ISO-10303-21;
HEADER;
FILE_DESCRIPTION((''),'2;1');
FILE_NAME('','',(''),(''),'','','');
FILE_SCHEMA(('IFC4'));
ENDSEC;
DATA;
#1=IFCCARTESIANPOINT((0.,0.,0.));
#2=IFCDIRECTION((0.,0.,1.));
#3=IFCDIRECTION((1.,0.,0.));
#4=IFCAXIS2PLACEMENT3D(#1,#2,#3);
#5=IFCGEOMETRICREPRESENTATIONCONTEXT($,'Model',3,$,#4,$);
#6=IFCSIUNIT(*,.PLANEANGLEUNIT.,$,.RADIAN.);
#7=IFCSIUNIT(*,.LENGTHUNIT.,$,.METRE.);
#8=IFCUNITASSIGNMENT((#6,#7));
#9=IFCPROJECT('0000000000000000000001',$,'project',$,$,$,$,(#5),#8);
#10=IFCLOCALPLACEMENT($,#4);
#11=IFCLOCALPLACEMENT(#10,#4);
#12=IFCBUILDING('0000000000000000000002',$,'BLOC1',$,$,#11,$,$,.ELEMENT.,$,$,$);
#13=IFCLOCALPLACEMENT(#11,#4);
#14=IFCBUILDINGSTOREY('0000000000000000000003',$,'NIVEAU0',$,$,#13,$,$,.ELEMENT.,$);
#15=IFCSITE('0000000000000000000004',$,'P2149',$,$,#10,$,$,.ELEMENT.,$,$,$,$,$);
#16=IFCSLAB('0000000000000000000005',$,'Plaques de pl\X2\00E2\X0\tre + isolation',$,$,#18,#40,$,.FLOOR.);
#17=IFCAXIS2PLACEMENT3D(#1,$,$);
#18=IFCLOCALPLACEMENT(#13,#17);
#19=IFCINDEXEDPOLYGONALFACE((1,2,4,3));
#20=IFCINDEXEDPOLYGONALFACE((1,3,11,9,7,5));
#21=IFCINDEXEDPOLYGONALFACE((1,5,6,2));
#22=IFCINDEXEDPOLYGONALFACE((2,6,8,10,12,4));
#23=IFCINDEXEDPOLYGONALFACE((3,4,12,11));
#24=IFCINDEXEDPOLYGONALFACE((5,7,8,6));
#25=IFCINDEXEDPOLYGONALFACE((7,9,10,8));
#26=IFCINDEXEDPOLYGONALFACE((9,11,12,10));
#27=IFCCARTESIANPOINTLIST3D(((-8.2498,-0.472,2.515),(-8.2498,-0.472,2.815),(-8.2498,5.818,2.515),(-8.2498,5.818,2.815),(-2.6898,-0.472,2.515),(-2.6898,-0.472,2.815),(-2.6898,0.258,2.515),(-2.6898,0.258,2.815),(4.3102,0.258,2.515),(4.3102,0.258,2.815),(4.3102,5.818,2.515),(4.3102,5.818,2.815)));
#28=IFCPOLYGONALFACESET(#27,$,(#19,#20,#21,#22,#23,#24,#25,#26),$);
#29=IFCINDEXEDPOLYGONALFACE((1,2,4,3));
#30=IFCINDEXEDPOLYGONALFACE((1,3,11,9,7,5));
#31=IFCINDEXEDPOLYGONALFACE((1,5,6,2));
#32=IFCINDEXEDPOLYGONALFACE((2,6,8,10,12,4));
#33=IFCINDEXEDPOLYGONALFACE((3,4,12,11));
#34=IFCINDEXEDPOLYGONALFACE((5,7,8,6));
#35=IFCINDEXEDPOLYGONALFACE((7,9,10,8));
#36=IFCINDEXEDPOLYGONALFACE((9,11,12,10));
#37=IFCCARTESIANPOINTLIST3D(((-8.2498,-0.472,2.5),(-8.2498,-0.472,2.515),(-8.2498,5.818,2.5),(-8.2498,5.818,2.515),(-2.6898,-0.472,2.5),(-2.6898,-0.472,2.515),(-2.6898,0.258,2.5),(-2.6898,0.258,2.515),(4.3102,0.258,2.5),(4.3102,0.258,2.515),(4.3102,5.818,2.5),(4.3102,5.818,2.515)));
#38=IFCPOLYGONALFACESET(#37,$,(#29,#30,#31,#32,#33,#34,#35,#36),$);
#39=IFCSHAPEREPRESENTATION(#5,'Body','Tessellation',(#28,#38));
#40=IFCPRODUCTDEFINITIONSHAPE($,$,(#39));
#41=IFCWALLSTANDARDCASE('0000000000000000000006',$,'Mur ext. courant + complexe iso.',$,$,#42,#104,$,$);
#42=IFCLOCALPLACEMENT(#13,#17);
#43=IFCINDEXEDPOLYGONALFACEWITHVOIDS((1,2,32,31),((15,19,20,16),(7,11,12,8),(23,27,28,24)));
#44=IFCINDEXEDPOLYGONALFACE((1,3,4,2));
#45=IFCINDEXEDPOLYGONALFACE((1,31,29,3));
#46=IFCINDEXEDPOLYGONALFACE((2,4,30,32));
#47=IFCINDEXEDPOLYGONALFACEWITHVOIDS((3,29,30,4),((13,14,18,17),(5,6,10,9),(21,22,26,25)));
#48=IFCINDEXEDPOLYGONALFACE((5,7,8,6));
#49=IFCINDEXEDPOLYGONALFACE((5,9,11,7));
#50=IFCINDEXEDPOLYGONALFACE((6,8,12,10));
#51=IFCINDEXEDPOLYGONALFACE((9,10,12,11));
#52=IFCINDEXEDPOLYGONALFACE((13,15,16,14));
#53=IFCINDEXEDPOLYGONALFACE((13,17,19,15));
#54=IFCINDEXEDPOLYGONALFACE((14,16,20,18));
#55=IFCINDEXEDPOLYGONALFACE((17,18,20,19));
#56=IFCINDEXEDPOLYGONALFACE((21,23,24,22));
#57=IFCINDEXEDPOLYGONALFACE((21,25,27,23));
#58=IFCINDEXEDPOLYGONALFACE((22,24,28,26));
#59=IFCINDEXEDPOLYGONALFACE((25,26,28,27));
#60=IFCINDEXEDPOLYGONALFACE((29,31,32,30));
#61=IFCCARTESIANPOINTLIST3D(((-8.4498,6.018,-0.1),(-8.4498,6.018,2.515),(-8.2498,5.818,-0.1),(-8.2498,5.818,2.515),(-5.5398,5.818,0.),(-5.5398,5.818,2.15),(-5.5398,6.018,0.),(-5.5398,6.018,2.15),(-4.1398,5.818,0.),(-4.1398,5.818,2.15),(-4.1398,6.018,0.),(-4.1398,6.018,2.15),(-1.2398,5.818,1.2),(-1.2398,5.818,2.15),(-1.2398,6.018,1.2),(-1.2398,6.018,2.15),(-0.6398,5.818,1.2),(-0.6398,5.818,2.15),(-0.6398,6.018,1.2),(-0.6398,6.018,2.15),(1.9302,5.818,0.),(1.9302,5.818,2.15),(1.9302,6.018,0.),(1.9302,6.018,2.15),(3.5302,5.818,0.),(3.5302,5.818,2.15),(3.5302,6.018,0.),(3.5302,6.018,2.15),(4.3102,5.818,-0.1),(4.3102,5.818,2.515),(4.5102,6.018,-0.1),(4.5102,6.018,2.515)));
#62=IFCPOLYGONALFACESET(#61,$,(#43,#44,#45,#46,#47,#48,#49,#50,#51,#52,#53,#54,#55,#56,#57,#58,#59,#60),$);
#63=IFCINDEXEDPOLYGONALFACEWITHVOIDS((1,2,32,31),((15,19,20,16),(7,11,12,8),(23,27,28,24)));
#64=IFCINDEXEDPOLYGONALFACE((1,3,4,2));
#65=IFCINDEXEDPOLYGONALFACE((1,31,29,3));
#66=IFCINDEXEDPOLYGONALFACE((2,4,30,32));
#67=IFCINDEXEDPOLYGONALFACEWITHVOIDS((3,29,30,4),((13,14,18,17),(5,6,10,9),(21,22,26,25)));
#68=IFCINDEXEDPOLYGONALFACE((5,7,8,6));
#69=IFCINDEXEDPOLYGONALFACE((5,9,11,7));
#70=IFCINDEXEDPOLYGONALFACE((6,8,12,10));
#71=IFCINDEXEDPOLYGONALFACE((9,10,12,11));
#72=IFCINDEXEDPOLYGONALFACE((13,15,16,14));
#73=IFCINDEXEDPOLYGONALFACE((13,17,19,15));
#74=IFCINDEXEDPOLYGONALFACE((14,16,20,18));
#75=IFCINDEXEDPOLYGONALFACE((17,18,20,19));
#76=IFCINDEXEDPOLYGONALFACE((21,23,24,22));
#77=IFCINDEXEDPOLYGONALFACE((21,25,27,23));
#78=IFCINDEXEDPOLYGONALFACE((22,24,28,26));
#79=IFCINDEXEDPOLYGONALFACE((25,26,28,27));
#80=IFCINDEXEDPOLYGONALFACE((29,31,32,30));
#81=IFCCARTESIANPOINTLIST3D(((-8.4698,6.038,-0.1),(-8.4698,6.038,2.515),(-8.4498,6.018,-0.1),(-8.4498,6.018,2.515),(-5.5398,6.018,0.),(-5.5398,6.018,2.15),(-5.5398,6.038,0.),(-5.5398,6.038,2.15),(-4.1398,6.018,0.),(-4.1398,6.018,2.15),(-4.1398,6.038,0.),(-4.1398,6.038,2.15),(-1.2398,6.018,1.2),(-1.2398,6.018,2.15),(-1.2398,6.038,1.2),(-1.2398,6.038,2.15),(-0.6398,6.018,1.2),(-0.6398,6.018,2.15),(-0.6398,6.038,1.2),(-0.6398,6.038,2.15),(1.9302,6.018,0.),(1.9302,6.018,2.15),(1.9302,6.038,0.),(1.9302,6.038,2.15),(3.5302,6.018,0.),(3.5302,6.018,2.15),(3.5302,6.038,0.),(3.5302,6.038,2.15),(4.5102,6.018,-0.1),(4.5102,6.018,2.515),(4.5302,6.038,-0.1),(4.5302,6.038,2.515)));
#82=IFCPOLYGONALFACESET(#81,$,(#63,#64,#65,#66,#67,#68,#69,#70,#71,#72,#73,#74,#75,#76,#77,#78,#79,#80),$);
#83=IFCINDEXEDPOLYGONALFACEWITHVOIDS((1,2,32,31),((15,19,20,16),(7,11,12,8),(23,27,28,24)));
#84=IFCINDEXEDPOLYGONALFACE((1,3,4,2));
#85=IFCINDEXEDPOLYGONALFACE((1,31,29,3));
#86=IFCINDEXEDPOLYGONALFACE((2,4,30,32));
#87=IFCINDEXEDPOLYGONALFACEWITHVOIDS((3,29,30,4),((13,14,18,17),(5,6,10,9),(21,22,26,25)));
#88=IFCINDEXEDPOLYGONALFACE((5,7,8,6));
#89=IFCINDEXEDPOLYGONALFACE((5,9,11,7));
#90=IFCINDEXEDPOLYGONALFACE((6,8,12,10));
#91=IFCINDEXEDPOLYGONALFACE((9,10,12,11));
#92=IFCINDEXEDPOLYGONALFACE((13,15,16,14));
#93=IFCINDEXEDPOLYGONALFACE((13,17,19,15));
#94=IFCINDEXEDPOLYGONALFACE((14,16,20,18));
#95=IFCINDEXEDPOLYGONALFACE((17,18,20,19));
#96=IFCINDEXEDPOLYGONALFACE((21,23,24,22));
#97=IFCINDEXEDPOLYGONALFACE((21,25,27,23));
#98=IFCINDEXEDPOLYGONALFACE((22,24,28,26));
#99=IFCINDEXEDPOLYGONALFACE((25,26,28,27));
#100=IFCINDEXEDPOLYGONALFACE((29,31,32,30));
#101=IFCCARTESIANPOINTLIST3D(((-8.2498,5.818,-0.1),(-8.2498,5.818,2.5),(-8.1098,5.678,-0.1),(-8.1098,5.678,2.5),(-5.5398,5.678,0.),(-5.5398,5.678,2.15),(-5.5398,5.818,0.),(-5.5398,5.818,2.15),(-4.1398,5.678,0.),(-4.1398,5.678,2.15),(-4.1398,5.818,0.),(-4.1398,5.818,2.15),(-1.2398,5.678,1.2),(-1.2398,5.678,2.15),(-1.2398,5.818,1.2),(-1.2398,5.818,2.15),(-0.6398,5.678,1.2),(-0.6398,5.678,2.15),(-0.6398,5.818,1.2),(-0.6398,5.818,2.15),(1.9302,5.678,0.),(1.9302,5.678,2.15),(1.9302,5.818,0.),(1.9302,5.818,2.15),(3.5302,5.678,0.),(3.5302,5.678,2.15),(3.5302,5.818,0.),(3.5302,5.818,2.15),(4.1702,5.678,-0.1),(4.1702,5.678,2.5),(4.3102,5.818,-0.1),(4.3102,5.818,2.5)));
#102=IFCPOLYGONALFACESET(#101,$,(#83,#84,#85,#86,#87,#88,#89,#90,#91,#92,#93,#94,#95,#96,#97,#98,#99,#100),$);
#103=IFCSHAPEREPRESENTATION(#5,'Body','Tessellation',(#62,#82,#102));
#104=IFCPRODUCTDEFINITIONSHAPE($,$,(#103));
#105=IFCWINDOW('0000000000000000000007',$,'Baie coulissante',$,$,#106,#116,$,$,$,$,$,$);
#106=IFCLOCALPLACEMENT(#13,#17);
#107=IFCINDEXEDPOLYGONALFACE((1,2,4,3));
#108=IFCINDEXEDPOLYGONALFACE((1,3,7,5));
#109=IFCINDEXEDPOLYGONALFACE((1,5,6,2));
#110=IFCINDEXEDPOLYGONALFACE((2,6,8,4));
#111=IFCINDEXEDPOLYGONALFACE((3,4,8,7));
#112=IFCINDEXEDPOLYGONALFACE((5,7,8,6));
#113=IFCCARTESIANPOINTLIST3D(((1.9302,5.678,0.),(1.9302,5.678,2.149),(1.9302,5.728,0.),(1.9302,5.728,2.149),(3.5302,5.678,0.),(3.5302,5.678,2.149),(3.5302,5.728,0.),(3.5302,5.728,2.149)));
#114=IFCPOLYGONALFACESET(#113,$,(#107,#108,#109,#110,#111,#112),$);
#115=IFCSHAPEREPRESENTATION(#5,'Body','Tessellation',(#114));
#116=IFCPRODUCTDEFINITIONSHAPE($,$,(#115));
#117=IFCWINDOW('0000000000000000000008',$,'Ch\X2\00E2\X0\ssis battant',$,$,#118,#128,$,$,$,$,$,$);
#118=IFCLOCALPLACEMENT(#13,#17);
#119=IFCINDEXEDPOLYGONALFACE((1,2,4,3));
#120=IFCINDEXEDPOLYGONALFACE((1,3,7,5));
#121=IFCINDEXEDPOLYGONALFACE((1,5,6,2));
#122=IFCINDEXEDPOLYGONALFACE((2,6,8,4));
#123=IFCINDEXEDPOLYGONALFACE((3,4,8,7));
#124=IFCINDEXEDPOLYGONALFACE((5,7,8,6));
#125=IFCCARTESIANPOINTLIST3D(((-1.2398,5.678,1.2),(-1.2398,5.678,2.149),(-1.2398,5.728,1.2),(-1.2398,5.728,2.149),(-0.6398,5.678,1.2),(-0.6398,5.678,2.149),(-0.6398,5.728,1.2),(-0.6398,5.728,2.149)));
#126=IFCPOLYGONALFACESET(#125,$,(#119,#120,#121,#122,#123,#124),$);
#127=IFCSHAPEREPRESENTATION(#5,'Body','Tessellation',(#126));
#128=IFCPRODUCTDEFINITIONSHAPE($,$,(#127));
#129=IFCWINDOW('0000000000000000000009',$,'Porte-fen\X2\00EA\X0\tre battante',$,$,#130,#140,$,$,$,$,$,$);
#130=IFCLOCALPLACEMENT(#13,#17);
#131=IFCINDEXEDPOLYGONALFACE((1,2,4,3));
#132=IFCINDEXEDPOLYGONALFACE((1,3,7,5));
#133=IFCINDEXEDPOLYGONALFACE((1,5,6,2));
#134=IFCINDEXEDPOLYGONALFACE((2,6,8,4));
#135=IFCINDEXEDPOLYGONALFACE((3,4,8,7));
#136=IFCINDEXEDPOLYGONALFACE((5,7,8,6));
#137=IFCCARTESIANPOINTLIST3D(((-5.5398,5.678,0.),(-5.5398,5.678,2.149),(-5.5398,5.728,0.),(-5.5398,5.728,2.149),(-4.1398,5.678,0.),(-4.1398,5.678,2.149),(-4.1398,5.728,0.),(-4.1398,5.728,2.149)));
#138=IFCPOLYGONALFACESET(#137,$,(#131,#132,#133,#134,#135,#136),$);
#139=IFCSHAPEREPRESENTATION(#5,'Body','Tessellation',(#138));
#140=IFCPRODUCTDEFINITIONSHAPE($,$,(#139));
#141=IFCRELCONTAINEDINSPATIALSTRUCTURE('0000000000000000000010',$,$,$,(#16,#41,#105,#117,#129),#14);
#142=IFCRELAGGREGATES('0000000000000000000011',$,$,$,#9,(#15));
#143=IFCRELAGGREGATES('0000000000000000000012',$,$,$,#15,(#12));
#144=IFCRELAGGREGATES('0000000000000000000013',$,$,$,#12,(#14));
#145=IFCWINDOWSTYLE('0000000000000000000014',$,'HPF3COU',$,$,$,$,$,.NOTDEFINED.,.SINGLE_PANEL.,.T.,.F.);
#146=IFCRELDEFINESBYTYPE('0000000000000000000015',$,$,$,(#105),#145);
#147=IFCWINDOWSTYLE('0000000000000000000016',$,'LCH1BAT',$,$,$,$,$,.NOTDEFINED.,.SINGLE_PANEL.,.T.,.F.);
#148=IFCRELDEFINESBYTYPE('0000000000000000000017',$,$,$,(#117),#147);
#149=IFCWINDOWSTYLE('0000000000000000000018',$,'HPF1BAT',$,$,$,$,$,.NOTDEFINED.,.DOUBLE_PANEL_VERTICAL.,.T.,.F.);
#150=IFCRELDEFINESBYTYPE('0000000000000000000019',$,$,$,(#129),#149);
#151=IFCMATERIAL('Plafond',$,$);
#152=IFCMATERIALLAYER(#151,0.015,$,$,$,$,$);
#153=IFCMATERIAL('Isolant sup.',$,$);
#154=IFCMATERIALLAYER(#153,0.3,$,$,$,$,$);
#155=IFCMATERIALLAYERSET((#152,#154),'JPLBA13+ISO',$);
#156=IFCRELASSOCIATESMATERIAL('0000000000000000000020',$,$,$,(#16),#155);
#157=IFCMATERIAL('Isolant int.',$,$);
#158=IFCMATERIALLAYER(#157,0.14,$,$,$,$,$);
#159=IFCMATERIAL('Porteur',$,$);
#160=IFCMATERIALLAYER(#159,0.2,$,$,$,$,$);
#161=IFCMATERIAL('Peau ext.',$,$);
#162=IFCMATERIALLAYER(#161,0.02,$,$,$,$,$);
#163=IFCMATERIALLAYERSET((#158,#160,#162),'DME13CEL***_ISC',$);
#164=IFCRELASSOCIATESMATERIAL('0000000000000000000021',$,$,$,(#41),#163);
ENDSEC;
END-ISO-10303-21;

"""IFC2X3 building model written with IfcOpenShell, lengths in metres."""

from ifc_helpers import new_model, si_unit, point, frame, frame_2d, origin_with_axes, place, context, project, spatial, line_curve, trimmed, segment, composite_curve, rectangle, outline, extrude, clip, bounded_halfspace, material, layer, layer_set, layer_usage, type_object, element, fill, save


model = new_model("IFC2X3")

# Units and contexts
model_context = context("Model", 3, world=origin_with_axes())
ifc_project = project(units=[si_unit("PLANEANGLEUNIT", "RADIAN"), si_unit("LENGTHUNIT", "METRE")], contexts=[model_context])

# Site, building, storey
site_placement = place(None, origin_with_axes())
site = spatial("IfcSite", under=ifc_project, at=site_placement, Name="P2149", CompositionType="ELEMENT")
building_placement = place(site_placement, origin_with_axes())
building = spatial("IfcBuilding", under=site, at=building_placement, Name="BLOC1", CompositionType="ELEMENT")
storey_placement = place(building_placement, origin_with_axes())
storey = spatial("IfcBuildingStorey", under=building, at=storey_placement, Name="NIVEAU0", CompositionType="ELEMENT")

# Slab
ifc_material_1 = material(Name="Plafond")
ifc_layer_1 = layer(ifc_material_1, 0.015)
ifc_material_2 = material(Name="Isolant sup.")
ifc_layer_2 = layer(ifc_material_2, 0.3)
ifc_layer_set_1 = layer_set([ifc_layer_1, ifc_layer_2], Name="JPLBA13+ISO")
ifc_layer_usage_1 = layer_usage(ifc_layer_set_1, "AXIS3", "POSITIVE", 0.0)
slab_placement = place(storey_placement, origin_with_axes())
element("IfcSlab", 1, at=slab_placement, inside=storey, material=ifc_layer_usage_1, Name="Plaques de plâtre + isolation", PredefinedType="FLOOR", context=model_context, shape_type="SweptSolid", body=[
    extrude(outline(composite_curve([segment(trimmed(line_curve((-8.2498, -0.472), (1.0, 0.0), 5.56), [point((-8.2498, -0.472))], [point((-2.6898, -0.472))], True, "CARTESIAN"), True, "CONTINUOUS"), segment(trimmed(line_curve((-2.6898, -0.472), (0.0, 1.0), 0.73), [point((-2.6898, -0.472))], [point((-2.6898, 0.258))], True, "CARTESIAN"), True, "CONTINUOUS"), segment(trimmed(line_curve((-2.6898, 0.258), (1.0, 0.0), 7.0), [point((-2.6898, 0.258))], [point((4.3102, 0.258))], True, "CARTESIAN"), True, "CONTINUOUS"), segment(trimmed(line_curve((4.3102, 0.258), (0.0, 1.0), 5.56), [point((4.3102, 0.258))], [point((4.3102, 5.818))], True, "CARTESIAN"), True, "CONTINUOUS"), segment(trimmed(line_curve((4.3102, 5.818), (-1.0, 0.0), 12.56), [point((4.3102, 5.818))], [point((-8.2498, 5.818))], True, "CARTESIAN"), True, "CONTINUOUS"), segment(trimmed(line_curve((-8.2498, 5.818), (0.0, -1.0), 6.29), [point((-8.2498, 5.818))], [point((-8.2498, -0.472))], True, "CARTESIAN"), True, "CONTINUOUS")], self_intersect=False)), frame((0.0, 0.0, 2.515), z_axis=(0.0, 0.0, 1.0), x_axis=(1.0, 0.0, 0.0)), (0.0, 0.0, 1.0), 0.3),
    extrude(outline(composite_curve([segment(trimmed(line_curve((-8.2498, -0.472), (1.0, 0.0), 5.56), [point((-8.2498, -0.472))], [point((-2.6898, -0.472))], True, "CARTESIAN"), True, "CONTINUOUS"), segment(trimmed(line_curve((-2.6898, -0.472), (0.0, 1.0), 0.73), [point((-2.6898, -0.472))], [point((-2.6898, 0.258))], True, "CARTESIAN"), True, "CONTINUOUS"), segment(trimmed(line_curve((-2.6898, 0.258), (1.0, 0.0), 7.0), [point((-2.6898, 0.258))], [point((4.3102, 0.258))], True, "CARTESIAN"), True, "CONTINUOUS"), segment(trimmed(line_curve((4.3102, 0.258), (0.0, 1.0), 5.56), [point((4.3102, 0.258))], [point((4.3102, 5.818))], True, "CARTESIAN"), True, "CONTINUOUS"), segment(trimmed(line_curve((4.3102, 5.818), (-1.0, 0.0), 12.56), [point((4.3102, 5.818))], [point((-8.2498, 5.818))], True, "CARTESIAN"), True, "CONTINUOUS"), segment(trimmed(line_curve((-8.2498, 5.818), (0.0, -1.0), 6.29), [point((-8.2498, 5.818))], [point((-8.2498, -0.472))], True, "CARTESIAN"), True, "CONTINUOUS")], self_intersect=False)), frame((0.0, 0.0, 2.5), z_axis=(0.0, 0.0, 1.0), x_axis=(1.0, 0.0, 0.0)), (0.0, 0.0, 1.0), 0.015),
])

# Wall, openings, windows
ifc_material_3 = material(Name="Isolant int.")
ifc_layer_3 = layer(ifc_material_3, 0.14)
ifc_material_4 = material(Name="Porteur")
ifc_layer_4 = layer(ifc_material_4, 0.2)
ifc_material_5 = material(Name="Peau ext.")
ifc_layer_5 = layer(ifc_material_5, 0.02)
ifc_layer_set_2 = layer_set([ifc_layer_3, ifc_layer_4, ifc_layer_5], Name="DME13CEL***_ISC")
ifc_layer_usage_2 = layer_usage(ifc_layer_set_2, "AXIS2", "POSITIVE", 0.0)
wall_1_placement = place(storey_placement, frame((-8.1098, 5.678, -0.1), z_axis=(0.0, 0.0, 1.0), x_axis=(1.0, 0.0, 0.0)))
wall_1 = element("IfcWallStandardCase", 2, at=wall_1_placement, inside=storey, material=ifc_layer_usage_2, Name="Mur ext. courant + complexe iso.", context=model_context, shape_type="Clipping", body=[
    extrude(outline(composite_curve([segment(trimmed(line_curve((-0.14, 0.14), (1.0, 0.0), 12.56), [point((-0.14, 0.14))], [point((12.42, 0.14))], True, "CARTESIAN"), True, "CONTINUOUS"), segment(trimmed(line_curve((12.42, 0.14), (0.707107, 0.707107), 0.282843), [point((12.42, 0.14))], [point((12.62, 0.34))], True, "CARTESIAN"), True, "CONTINUOUS"), segment(trimmed(line_curve((12.62, 0.34), (-1.0, 0.0), 12.96), [point((12.62, 0.34))], [point((-0.34, 0.34))], True, "CARTESIAN"), True, "CONTINUOUS"), segment(trimmed(line_curve((-0.34, 0.34), (0.707107, -0.707107), 0.282843), [point((-0.34, 0.34))], [point((-0.14, 0.14))], True, "CARTESIAN"), True, "CONTINUOUS")], self_intersect=False)), origin_with_axes(), (0.0, 0.0, 1.0), 2.615),
    extrude(outline(composite_curve([segment(trimmed(line_curve((-0.34, 0.34), (1.0, 0.0), 12.96), [point((-0.34, 0.34))], [point((12.62, 0.34))], True, "CARTESIAN"), True, "CONTINUOUS"), segment(trimmed(line_curve((12.62, 0.34), (0.707107, 0.707107), 0.028284), [point((12.62, 0.34))], [point((12.64, 0.36))], True, "CARTESIAN"), True, "CONTINUOUS"), segment(trimmed(line_curve((12.64, 0.36), (-1.0, 0.0), 13.0), [point((12.64, 0.36))], [point((-0.36, 0.36))], True, "CARTESIAN"), True, "CONTINUOUS"), segment(trimmed(line_curve((-0.36, 0.36), (0.707107, -0.707107), 0.028284), [point((-0.36, 0.36))], [point((-0.34, 0.34))], True, "CARTESIAN"), True, "CONTINUOUS")], self_intersect=False)), origin_with_axes(), (0.0, 0.0, 1.0), 2.615),
    clip(extrude(outline(composite_curve([segment(trimmed(line_curve((0.0, 0.0), (1.0, 0.0), 12.28), [point((0.0, 0.0))], [point((12.28, 0.0))], True, "CARTESIAN"), True, "CONTINUOUS"), segment(trimmed(line_curve((12.28, 0.0), (0.707107, 0.707107), 0.19799), [point((12.28, 0.0))], [point((12.42, 0.14))], True, "CARTESIAN"), True, "CONTINUOUS"), segment(trimmed(line_curve((12.42, 0.14), (-1.0, 0.0), 12.56), [point((12.42, 0.14))], [point((-0.14, 0.14))], True, "CARTESIAN"), True, "CONTINUOUS"), segment(trimmed(line_curve((-0.14, 0.14), (0.707107, -0.707107), 0.19799), [point((-0.14, 0.14))], [point((0.0, 0.0))], True, "CARTESIAN"), True, "CONTINUOUS")], self_intersect=False)), origin_with_axes(), (0.0, 0.0, 1.0), 2.615), bounded_halfspace(frame((0.0, 0.0, 2.6), z_axis=(0.0, 0.0, 1.0), x_axis=(0.0, 1.0, 0.0)), False, frame((0.0, 0.0, 2.6), z_axis=(0.0, 0.0, 1.0), x_axis=(1.0, 0.0, 0.0)), composite_curve([segment(trimmed(line_curve((0.0, 0.0), (1.0, 0.0), 12.28), [point((0.0, 0.0))], [point((12.28, 0.0))], True, "CARTESIAN"), True, "CONTINUOUS"), segment(trimmed(line_curve((12.28, 0.0), (0.707107, 0.707107), 0.19799), [point((12.28, 0.0))], [point((12.42, 0.14))], True, "CARTESIAN"), True, "CONTINUOUS"), segment(trimmed(line_curve((12.42, 0.14), (-1.0, 0.0), 12.56), [point((12.42, 0.14))], [point((-0.14, 0.14))], True, "CARTESIAN"), True, "CONTINUOUS"), segment(trimmed(line_curve((-0.14, 0.14), (0.707107, -0.707107), 0.19799), [point((-0.14, 0.14))], [point((0.0, 0.0))], True, "CARTESIAN"), True, "CONTINUOUS")], self_intersect=False))),
])
opening_1_placement = place(wall_1_placement, frame((10.04, 0.0, 0.1), z_axis=(0.0, -1.0, 0.0), x_axis=(1.0, 0.0, 0.0)))
opening_1 = element("IfcOpeningElement", 3, at=opening_1_placement, cuts=wall_1, context=model_context, shape_type="SweptSolid", body=[
    extrude(rectangle(XDim=1.6, YDim=2.15, at=frame_2d((0.8, 1.075), x_axis=(1.0, 0.0))), origin_with_axes(), (0.0, 0.0, -1.0), 0.36),
])
opening_2_placement = place(wall_1_placement, frame((7.47, 0.0, 1.3), z_axis=(0.0, 1.0, 0.0), x_axis=(-1.0, 0.0, 0.0)))
opening_2 = element("IfcOpeningElement", 4, at=opening_2_placement, cuts=wall_1, context=model_context, shape_type="SweptSolid", body=[
    extrude(rectangle(XDim=0.6, YDim=0.95, at=frame_2d((0.3, 0.475), x_axis=(1.0, 0.0))), origin_with_axes(), (0.0, 0.0, 1.0), 0.36),
])
opening_3_placement = place(wall_1_placement, frame((2.57, 0.0, 0.1), z_axis=(0.0, -1.0, 0.0), x_axis=(1.0, 0.0, 0.0)))
opening_3 = element("IfcOpeningElement", 5, at=opening_3_placement, cuts=wall_1, context=model_context, shape_type="SweptSolid", body=[
    extrude(rectangle(XDim=1.4, YDim=2.15, at=frame_2d((0.7, 1.075), x_axis=(1.0, 0.0))), origin_with_axes(), (0.0, 0.0, -1.0), 0.36),
])
window_style_1 = type_object("IfcWindowStyle", Name="HPF3COU", ConstructionType="NOTDEFINED", OperationType="SINGLE_PANEL", ParameterTakesPrecedence=True, Sizeable=False)
window_1_placement = place(opening_1_placement, origin_with_axes())
window_1 = element("IfcWindow", 6, at=window_1_placement, inside=storey, type_object=window_style_1, Name="Baie coulissante", context=model_context, shape_type="SweptSolid", body=[
    extrude(rectangle(XDim=1.6, YDim=2.149, at=frame_2d((0.8, 1.0745), x_axis=(1.0, 0.0))), origin_with_axes(), (0.0, 0.0, -1.0), 0.05),
])
fill(opening_1, window_1)
window_style_2 = type_object("IfcWindowStyle", Name="LCH1BAT", ConstructionType="NOTDEFINED", OperationType="SINGLE_PANEL", ParameterTakesPrecedence=True, Sizeable=False)
window_2_placement = place(opening_2_placement, origin_with_axes())
window_2 = element("IfcWindow", 7, at=window_2_placement, inside=storey, type_object=window_style_2, Name="Châssis battant", context=model_context, shape_type="SweptSolid", body=[
    extrude(rectangle(XDim=0.6, YDim=0.949, at=frame_2d((0.3, 0.4745), x_axis=(1.0, 0.0))), origin_with_axes(), (0.0, 0.0, 1.0), 0.05),
])
fill(opening_2, window_2)
window_style_3 = type_object("IfcWindowStyle", Name="HPF1BAT", ConstructionType="NOTDEFINED", OperationType="DOUBLE_PANEL_VERTICAL", ParameterTakesPrecedence=True, Sizeable=False)
window_3_placement = place(opening_3_placement, origin_with_axes())
window_3 = element("IfcWindow", 8, at=window_3_placement, inside=storey, type_object=window_style_3, Name="Porte-fenêtre battante", context=model_context, shape_type="SweptSolid", body=[
    extrude(rectangle(XDim=1.4, YDim=2.149, at=frame_2d((0.7, 1.0745), x_axis=(1.0, 0.0))), origin_with_axes(), (0.0, 0.0, -1.0), 0.05),
])
fill(opening_3, window_3)

save(model, "model.ifc")
